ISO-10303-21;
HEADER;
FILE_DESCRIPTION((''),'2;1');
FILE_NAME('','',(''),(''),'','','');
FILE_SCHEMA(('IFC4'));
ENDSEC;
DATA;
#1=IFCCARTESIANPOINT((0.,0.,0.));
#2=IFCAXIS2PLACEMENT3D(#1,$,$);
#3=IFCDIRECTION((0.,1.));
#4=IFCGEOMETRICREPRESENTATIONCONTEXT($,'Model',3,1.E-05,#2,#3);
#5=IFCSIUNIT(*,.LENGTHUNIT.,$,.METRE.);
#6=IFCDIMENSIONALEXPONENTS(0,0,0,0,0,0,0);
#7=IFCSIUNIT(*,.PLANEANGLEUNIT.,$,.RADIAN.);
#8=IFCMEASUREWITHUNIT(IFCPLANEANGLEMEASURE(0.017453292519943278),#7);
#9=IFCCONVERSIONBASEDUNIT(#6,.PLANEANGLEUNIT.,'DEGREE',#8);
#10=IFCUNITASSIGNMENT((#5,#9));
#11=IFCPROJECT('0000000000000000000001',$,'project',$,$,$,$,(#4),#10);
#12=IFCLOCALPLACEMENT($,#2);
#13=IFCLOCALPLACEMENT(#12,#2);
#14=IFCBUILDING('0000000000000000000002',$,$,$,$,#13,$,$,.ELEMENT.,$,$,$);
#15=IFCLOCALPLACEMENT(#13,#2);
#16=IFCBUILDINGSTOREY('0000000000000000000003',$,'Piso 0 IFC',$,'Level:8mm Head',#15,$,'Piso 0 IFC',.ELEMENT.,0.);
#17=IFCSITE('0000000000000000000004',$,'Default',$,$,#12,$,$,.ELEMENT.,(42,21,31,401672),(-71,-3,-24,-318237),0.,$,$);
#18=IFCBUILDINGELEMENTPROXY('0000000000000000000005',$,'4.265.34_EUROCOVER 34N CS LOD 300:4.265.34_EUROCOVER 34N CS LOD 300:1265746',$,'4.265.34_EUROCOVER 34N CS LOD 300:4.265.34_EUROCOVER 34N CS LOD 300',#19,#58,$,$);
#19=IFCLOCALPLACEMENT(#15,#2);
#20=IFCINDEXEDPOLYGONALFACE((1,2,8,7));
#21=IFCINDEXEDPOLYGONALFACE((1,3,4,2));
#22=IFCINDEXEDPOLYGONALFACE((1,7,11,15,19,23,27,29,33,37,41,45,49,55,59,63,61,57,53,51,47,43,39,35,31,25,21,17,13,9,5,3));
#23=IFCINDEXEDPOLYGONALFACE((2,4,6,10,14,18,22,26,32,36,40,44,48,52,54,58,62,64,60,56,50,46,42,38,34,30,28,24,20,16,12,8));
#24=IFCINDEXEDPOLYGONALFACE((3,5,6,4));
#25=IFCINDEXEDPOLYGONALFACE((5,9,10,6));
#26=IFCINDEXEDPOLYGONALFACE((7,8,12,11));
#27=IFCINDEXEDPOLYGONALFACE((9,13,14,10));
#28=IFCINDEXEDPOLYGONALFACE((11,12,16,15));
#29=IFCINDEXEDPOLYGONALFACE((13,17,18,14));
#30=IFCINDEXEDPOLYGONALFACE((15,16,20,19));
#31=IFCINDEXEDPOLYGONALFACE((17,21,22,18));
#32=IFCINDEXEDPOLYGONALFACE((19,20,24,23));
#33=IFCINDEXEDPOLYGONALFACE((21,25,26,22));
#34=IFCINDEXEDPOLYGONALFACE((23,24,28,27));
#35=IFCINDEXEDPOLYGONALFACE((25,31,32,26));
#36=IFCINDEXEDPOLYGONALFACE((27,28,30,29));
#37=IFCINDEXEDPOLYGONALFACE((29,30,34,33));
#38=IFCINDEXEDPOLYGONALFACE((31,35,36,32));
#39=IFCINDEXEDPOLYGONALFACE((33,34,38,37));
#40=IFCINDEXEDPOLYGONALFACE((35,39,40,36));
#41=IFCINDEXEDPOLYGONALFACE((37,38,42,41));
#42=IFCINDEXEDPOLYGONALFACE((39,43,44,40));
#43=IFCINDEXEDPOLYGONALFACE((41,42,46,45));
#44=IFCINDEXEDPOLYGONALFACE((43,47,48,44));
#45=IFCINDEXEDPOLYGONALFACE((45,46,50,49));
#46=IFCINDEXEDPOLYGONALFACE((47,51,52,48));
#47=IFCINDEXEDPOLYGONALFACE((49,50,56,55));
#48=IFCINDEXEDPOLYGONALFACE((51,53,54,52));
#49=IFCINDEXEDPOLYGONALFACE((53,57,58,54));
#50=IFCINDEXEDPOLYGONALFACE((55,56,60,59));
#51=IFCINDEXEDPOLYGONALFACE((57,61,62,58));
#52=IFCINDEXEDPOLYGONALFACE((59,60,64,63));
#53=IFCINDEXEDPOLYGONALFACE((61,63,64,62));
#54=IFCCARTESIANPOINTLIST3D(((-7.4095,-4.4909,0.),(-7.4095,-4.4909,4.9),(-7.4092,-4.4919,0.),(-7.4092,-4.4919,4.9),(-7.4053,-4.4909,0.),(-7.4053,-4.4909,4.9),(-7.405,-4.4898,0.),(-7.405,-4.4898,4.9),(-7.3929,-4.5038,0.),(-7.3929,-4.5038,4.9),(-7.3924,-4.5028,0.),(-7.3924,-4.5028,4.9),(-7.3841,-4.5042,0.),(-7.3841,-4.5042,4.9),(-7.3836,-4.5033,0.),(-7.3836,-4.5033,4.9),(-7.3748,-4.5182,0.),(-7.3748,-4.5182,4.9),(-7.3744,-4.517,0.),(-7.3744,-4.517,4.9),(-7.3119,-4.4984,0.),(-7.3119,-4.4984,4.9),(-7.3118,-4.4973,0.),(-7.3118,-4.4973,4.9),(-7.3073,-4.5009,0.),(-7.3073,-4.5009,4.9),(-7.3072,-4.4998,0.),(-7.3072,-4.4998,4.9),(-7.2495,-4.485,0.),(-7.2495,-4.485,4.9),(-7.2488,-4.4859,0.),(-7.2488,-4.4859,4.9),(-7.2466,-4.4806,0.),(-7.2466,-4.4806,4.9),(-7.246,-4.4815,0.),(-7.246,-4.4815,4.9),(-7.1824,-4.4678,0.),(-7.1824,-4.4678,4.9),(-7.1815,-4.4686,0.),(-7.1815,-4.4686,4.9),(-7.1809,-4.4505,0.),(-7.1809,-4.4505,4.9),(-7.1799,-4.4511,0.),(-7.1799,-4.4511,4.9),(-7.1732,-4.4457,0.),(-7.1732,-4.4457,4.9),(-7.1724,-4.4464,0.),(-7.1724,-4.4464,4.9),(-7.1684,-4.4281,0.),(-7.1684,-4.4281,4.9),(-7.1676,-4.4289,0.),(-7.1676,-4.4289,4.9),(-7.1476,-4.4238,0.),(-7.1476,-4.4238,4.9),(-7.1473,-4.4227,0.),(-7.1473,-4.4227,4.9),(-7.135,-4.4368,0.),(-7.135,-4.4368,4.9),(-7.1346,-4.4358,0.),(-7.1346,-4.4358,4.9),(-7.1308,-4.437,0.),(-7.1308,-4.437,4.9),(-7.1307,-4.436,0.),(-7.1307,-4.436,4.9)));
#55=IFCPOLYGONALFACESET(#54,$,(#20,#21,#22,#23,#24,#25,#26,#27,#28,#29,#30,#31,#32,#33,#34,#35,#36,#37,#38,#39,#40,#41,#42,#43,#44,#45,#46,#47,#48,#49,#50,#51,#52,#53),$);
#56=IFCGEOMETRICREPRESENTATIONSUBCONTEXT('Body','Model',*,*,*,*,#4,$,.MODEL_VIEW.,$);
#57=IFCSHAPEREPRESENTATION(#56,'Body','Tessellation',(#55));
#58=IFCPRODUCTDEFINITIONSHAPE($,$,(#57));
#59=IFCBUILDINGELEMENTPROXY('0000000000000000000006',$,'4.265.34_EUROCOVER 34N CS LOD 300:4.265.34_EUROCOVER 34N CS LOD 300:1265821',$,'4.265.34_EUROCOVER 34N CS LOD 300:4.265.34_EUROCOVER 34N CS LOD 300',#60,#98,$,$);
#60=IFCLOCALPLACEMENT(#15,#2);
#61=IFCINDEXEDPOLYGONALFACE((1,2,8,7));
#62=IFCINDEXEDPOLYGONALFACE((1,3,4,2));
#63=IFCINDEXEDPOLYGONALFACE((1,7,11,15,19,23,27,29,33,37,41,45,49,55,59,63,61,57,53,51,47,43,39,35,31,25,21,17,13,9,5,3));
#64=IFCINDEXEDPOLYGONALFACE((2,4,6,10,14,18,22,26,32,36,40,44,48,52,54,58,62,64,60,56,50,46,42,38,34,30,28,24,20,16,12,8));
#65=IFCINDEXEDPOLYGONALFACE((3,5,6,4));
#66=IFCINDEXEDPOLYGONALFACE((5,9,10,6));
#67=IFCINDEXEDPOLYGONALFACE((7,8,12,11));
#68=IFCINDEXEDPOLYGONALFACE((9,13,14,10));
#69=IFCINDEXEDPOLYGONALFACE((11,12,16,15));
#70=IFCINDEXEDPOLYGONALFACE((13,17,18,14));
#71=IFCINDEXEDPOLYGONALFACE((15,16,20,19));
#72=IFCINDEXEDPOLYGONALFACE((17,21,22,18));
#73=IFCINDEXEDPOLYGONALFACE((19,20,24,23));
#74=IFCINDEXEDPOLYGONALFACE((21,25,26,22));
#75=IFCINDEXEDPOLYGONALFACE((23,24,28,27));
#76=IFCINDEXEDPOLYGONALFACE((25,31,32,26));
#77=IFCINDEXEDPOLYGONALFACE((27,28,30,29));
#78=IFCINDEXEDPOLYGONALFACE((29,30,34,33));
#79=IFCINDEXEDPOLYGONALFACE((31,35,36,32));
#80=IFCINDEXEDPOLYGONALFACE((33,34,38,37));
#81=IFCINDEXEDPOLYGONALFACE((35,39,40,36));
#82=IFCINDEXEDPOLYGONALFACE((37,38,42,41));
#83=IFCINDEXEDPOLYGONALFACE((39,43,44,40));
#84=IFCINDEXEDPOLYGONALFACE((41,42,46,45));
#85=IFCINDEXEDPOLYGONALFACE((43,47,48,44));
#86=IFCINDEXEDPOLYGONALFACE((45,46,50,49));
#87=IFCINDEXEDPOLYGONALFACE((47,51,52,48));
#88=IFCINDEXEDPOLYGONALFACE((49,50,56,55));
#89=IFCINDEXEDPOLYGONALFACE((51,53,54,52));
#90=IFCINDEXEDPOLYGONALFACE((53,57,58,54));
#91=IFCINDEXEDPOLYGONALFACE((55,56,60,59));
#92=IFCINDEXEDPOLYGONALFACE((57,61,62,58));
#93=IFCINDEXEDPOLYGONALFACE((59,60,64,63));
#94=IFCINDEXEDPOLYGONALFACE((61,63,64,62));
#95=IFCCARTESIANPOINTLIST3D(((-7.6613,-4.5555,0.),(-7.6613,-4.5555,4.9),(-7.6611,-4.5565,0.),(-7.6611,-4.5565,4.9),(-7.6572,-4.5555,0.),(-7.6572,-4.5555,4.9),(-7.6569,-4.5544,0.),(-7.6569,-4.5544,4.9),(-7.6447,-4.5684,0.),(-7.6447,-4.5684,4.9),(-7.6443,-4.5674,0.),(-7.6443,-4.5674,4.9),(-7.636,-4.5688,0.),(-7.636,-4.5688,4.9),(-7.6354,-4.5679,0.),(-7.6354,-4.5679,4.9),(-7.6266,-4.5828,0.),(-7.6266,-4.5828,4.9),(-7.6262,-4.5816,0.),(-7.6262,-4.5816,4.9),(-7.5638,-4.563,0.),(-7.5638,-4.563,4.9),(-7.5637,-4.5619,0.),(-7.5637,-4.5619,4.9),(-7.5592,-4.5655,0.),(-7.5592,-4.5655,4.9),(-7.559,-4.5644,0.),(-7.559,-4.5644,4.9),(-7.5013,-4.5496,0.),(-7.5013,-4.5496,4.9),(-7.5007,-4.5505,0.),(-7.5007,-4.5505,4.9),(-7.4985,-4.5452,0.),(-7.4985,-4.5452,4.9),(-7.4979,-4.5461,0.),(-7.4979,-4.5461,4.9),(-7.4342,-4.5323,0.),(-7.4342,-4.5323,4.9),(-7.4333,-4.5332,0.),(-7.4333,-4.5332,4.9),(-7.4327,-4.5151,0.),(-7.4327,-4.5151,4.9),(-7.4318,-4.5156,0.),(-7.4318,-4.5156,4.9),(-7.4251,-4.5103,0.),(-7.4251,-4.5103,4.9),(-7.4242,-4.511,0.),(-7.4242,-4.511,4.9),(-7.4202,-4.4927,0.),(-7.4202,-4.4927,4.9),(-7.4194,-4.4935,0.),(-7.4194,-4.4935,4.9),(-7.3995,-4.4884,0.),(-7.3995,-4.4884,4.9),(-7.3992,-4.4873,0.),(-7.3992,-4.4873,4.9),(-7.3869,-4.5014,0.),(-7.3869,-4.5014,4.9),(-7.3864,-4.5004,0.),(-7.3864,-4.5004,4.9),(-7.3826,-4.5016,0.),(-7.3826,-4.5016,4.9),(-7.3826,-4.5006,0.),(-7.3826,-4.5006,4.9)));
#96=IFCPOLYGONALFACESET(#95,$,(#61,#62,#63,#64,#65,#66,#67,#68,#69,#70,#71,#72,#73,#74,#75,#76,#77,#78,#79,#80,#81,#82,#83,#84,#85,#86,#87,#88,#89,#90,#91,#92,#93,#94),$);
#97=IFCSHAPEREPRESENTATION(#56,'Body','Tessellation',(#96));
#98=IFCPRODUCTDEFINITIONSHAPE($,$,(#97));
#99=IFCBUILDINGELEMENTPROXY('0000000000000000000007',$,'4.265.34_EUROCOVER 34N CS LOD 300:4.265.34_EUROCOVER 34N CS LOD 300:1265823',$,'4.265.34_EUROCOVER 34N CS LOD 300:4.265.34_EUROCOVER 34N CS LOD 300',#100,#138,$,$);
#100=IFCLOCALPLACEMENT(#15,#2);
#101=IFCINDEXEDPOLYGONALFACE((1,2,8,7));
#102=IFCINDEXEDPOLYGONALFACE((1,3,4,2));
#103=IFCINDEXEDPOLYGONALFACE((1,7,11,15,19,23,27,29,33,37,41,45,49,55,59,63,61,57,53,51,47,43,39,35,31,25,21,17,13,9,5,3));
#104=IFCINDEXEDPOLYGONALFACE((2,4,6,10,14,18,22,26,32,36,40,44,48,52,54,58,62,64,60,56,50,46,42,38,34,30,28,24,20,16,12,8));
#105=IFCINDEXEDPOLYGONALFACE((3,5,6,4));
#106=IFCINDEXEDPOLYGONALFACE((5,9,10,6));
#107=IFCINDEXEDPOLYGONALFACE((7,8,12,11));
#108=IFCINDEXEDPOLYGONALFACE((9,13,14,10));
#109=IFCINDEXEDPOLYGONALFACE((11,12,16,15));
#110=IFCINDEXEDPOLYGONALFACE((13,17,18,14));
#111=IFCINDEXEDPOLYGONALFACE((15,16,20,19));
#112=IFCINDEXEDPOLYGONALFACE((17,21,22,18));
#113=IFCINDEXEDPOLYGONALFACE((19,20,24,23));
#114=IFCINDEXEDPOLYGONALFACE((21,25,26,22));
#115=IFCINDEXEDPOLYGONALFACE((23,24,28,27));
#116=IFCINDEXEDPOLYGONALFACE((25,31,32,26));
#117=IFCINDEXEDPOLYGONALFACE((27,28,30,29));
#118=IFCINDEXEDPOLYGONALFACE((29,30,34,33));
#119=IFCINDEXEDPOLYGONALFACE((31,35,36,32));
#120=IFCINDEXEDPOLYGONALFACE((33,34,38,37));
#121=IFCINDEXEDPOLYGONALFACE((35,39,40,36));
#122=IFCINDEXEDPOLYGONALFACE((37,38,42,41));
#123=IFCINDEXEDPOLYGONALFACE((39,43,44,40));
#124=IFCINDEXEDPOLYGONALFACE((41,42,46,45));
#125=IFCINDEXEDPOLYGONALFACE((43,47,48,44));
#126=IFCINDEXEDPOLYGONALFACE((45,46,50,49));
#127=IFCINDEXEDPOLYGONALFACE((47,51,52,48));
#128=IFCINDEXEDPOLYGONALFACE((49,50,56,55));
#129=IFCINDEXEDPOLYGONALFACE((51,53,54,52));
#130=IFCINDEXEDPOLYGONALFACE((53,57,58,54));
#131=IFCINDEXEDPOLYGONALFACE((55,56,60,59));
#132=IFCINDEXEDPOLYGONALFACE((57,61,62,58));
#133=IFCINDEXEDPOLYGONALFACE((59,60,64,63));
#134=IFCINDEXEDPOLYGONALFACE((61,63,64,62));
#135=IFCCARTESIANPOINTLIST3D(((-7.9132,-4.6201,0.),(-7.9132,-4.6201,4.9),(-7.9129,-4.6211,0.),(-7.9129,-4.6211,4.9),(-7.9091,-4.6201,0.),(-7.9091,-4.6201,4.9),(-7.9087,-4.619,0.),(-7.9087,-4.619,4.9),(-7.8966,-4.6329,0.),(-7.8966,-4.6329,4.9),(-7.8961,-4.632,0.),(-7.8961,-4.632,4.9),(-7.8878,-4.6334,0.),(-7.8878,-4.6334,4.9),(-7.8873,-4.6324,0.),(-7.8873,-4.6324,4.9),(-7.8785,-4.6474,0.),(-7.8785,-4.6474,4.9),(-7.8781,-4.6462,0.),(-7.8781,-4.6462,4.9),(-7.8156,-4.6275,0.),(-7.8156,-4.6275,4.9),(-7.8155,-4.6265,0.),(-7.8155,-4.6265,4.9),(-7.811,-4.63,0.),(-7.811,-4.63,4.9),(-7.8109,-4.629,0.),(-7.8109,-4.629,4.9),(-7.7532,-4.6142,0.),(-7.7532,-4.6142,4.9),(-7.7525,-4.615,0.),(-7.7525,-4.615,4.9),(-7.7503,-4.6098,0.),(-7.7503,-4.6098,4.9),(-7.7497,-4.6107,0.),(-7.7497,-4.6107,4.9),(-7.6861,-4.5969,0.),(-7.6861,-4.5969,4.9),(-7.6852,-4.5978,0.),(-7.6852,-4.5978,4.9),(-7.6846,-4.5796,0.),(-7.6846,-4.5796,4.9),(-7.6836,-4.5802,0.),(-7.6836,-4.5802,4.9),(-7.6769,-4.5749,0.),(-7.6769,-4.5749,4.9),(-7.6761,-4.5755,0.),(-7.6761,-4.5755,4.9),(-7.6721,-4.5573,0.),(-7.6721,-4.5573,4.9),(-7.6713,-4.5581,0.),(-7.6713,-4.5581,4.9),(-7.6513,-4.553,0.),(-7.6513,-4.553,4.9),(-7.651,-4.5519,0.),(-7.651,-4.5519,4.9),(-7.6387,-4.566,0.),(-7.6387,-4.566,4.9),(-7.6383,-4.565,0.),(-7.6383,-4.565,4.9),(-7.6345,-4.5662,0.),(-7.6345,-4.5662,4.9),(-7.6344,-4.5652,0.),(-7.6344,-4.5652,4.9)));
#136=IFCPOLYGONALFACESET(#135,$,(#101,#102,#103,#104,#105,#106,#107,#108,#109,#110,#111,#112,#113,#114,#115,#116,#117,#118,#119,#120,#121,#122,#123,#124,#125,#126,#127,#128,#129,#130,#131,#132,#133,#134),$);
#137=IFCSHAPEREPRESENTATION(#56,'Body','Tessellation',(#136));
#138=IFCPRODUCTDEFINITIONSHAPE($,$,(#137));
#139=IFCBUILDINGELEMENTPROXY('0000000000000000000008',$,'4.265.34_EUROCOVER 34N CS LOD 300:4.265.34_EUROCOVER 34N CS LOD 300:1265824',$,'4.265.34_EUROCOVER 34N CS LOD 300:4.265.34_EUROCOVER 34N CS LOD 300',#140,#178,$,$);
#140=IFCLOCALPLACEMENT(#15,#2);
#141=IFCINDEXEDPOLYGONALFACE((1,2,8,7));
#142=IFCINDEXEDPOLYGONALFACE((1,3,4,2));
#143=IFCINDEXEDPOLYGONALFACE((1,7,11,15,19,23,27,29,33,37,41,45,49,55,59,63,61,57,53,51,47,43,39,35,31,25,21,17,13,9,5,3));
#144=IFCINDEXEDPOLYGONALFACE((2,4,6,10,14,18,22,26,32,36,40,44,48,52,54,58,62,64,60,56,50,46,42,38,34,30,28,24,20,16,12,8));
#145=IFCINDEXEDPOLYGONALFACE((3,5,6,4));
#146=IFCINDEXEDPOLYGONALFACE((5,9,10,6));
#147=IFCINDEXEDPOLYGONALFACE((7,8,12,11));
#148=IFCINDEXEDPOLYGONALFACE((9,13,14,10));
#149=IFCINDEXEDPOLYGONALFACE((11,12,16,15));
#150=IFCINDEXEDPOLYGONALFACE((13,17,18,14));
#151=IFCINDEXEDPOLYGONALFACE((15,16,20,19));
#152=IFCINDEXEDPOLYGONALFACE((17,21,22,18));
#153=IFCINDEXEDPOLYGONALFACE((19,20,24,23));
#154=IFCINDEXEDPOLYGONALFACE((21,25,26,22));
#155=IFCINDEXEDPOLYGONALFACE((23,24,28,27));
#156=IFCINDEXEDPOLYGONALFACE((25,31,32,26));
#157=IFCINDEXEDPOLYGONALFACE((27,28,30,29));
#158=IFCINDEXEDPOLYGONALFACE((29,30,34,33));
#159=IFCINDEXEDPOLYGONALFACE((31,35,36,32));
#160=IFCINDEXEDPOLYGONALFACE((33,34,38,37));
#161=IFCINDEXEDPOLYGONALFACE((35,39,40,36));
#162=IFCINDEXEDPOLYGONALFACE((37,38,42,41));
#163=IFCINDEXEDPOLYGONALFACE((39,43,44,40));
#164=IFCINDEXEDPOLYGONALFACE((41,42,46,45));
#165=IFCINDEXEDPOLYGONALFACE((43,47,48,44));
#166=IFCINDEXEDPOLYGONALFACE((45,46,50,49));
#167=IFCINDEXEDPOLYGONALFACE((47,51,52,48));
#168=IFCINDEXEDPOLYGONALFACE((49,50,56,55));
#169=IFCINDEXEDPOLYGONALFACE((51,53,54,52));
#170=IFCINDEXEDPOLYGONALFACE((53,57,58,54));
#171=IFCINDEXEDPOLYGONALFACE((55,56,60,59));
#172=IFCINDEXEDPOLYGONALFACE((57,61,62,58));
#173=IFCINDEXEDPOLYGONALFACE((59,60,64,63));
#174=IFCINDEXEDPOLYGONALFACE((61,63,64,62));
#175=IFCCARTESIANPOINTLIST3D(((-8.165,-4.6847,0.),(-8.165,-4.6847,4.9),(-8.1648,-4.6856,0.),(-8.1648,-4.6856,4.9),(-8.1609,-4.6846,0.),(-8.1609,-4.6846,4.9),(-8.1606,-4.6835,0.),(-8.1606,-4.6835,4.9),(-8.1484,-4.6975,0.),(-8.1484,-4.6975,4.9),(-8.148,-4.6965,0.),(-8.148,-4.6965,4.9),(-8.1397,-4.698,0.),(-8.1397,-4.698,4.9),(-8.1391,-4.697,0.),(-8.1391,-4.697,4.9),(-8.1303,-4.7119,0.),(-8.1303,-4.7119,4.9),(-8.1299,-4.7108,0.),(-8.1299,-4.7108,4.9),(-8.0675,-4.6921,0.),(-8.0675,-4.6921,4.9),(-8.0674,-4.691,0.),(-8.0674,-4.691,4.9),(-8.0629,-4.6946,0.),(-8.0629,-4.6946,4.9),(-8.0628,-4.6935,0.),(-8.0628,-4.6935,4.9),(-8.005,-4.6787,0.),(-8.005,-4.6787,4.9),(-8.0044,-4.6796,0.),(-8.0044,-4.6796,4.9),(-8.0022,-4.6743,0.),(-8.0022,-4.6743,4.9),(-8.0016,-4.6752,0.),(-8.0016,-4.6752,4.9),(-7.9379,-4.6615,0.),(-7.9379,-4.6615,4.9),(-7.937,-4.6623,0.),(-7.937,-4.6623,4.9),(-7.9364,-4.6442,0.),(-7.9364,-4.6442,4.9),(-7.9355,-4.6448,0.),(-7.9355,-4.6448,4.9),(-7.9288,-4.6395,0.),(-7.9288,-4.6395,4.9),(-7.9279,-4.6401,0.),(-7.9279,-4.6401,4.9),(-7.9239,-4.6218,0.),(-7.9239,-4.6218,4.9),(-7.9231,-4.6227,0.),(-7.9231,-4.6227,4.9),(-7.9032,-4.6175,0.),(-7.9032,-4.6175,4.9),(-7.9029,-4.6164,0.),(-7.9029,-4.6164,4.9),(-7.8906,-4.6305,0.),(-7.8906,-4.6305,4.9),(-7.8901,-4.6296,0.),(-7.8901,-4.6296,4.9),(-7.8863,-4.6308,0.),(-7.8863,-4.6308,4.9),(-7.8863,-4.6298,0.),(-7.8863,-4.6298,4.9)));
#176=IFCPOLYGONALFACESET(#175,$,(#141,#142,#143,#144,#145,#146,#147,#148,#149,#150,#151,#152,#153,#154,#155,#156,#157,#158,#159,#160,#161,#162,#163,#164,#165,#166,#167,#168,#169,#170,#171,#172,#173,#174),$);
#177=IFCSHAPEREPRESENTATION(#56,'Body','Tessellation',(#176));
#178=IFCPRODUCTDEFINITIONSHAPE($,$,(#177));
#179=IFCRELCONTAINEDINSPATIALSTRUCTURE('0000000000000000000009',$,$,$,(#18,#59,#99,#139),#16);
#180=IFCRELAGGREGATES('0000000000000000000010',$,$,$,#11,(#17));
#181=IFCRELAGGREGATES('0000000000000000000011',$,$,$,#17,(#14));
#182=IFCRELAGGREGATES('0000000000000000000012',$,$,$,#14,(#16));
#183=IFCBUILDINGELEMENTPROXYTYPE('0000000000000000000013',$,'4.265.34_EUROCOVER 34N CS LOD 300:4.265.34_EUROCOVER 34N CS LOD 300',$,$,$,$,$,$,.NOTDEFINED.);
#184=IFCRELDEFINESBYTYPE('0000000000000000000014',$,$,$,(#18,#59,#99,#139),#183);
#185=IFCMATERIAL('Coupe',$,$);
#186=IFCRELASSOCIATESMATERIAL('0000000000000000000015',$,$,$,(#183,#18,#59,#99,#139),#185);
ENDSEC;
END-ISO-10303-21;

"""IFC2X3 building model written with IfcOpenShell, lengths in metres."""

from ifc_helpers import new_model, entity, si_unit, converted_unit, direction, frame, origin, place, context, subcontext, project, spatial, polyline, outline, extrude, source, transform, mapped, material, type_object, type_shapes, element, save


model = new_model("IFC2X3")

# Units and contexts
model_context = context("Model", 3, precision=1e-05, world=origin(), true_north=direction((0.0, 1.0)))
body_context = subcontext(model_context, "Body", "Model", "MODEL_VIEW")
ifc_project = project(units=[si_unit("LENGTHUNIT", "METRE"), converted_unit("PLANEANGLEUNIT", "DEGREE", entity("IfcPlaneAngleMeasure", 0.017453292519943278), si_unit("PLANEANGLEUNIT", "RADIAN"), dimensions=[0, 0, 0, 0, 0, 0, 0])], contexts=[model_context])

# Site, building, storey
site_placement = place(None, origin())
site = spatial("IfcSite", under=ifc_project, at=site_placement, Name="Default", CompositionType="ELEMENT", RefLatitude=(42, 21, 31, 401672), RefLongitude=(-71, -3, -24, -318237), RefElevation=0.0)
building_placement = place(site_placement, origin())
building = spatial("IfcBuilding", under=site, at=building_placement, CompositionType="ELEMENT")
storey_placement = place(building_placement, origin())
storey = spatial("IfcBuildingStorey", under=building, at=storey_placement, Name="Piso 0 IFC", ObjectType="Level:8mm Head", LongName="Piso 0 IFC", CompositionType="ELEMENT", Elevation=0.0)

# Building element proxies
ifc_material_1 = material(Name="Coupe")
building_element_proxy_type = type_object("IfcBuildingElementProxyType", Name="4.265.34_EUROCOVER 34N CS LOD 300:4.265.34_EUROCOVER 34N CS LOD 300", PredefinedType="NOTDEFINED", material=ifc_material_1)
shared_shape = source(origin(), body_context, "Body", "SweptSolid", [
    extrude(outline(polyline([(0.0449, 0.1162), (0.063, 0.1162), (0.0661, 0.1191), (0.0654, 0.1198), (0.0626, 0.1172), (0.0443, 0.1172), (0.0335, 0.0983), (0.0428, 0.0826), (0.0409, 0.0738), (0.0522, 0.0606), (0.0167, 0.0056), (0.0179, 0.0005), (-0.0117, -0.0512), (-0.0167, -0.0528), (-0.0462, -0.1114), (-0.0624, -0.1084), (-0.069, -0.1145), (-0.0871, -0.1145), (-0.0893, -0.1184), (-0.0885, -0.1189), (-0.0865, -0.1155), (-0.0686, -0.1155), (-0.0621, -0.1095), (-0.0456, -0.1125), (-0.016, -0.0536), (-0.0111, -0.0521), (0.0189, 0.0004), (0.0177, 0.0054), (0.0535, 0.0607), (0.0419, 0.074), (0.0438, 0.0827), (0.0347, 0.0983), (0.0449, 0.1162)])), frame((-0.0171, -0.0163, 0.0), z_axis=(0.0, 0.0, 1.0), x_axis=(-0.496574, 0.867994, 0.0)), (0.0, 0.0, 1.0), 4.9),
])
type_shapes(building_element_proxy_type, [shared_shape])
for number, where, z_axis, x_axis, name in (
    (1, (-7.2748, -4.4926, 0.0), (0.0, 0.0, 1.0), (-0.968666, -0.248367, 0.0), "4.265.34_EUROCOVER 34N CS LOD 300:4.265.34_EUROCOVER 34N CS LOD 300:1265746"),
    (2, (-7.5267, -4.5572, 0.0), (0.0, 0.0, 1.0), (-0.968666, -0.248367, 0.0), "4.265.34_EUROCOVER 34N CS LOD 300:4.265.34_EUROCOVER 34N CS LOD 300:1265821"),
    (3, (-7.7785, -4.6217, 0.0), (0.0, 0.0, 1.0), (-0.968666, -0.248367, 0.0), "4.265.34_EUROCOVER 34N CS LOD 300:4.265.34_EUROCOVER 34N CS LOD 300:1265823"),
    (4, (-8.0304, -4.6863, 0.0), (0.0, 0.0, 1.0), (-0.968666, -0.248367, 0.0), "4.265.34_EUROCOVER 34N CS LOD 300:4.265.34_EUROCOVER 34N CS LOD 300:1265824"),
):
    element("IfcBuildingElementProxy", number, at=place(storey_placement, frame(where, z_axis=z_axis, x_axis=x_axis)), inside=storey, type_object=building_element_proxy_type, material=ifc_material_1, Name=name, ObjectType="4.265.34_EUROCOVER 34N CS LOD 300:4.265.34_EUROCOVER 34N CS LOD 300", context=body_context, shape_type="MappedRepresentation", body=[
        mapped(shared_shape, transform((0.0, 0.0, 0.0), scale=1.0)),
    ])

save(model, "model.ifc")
